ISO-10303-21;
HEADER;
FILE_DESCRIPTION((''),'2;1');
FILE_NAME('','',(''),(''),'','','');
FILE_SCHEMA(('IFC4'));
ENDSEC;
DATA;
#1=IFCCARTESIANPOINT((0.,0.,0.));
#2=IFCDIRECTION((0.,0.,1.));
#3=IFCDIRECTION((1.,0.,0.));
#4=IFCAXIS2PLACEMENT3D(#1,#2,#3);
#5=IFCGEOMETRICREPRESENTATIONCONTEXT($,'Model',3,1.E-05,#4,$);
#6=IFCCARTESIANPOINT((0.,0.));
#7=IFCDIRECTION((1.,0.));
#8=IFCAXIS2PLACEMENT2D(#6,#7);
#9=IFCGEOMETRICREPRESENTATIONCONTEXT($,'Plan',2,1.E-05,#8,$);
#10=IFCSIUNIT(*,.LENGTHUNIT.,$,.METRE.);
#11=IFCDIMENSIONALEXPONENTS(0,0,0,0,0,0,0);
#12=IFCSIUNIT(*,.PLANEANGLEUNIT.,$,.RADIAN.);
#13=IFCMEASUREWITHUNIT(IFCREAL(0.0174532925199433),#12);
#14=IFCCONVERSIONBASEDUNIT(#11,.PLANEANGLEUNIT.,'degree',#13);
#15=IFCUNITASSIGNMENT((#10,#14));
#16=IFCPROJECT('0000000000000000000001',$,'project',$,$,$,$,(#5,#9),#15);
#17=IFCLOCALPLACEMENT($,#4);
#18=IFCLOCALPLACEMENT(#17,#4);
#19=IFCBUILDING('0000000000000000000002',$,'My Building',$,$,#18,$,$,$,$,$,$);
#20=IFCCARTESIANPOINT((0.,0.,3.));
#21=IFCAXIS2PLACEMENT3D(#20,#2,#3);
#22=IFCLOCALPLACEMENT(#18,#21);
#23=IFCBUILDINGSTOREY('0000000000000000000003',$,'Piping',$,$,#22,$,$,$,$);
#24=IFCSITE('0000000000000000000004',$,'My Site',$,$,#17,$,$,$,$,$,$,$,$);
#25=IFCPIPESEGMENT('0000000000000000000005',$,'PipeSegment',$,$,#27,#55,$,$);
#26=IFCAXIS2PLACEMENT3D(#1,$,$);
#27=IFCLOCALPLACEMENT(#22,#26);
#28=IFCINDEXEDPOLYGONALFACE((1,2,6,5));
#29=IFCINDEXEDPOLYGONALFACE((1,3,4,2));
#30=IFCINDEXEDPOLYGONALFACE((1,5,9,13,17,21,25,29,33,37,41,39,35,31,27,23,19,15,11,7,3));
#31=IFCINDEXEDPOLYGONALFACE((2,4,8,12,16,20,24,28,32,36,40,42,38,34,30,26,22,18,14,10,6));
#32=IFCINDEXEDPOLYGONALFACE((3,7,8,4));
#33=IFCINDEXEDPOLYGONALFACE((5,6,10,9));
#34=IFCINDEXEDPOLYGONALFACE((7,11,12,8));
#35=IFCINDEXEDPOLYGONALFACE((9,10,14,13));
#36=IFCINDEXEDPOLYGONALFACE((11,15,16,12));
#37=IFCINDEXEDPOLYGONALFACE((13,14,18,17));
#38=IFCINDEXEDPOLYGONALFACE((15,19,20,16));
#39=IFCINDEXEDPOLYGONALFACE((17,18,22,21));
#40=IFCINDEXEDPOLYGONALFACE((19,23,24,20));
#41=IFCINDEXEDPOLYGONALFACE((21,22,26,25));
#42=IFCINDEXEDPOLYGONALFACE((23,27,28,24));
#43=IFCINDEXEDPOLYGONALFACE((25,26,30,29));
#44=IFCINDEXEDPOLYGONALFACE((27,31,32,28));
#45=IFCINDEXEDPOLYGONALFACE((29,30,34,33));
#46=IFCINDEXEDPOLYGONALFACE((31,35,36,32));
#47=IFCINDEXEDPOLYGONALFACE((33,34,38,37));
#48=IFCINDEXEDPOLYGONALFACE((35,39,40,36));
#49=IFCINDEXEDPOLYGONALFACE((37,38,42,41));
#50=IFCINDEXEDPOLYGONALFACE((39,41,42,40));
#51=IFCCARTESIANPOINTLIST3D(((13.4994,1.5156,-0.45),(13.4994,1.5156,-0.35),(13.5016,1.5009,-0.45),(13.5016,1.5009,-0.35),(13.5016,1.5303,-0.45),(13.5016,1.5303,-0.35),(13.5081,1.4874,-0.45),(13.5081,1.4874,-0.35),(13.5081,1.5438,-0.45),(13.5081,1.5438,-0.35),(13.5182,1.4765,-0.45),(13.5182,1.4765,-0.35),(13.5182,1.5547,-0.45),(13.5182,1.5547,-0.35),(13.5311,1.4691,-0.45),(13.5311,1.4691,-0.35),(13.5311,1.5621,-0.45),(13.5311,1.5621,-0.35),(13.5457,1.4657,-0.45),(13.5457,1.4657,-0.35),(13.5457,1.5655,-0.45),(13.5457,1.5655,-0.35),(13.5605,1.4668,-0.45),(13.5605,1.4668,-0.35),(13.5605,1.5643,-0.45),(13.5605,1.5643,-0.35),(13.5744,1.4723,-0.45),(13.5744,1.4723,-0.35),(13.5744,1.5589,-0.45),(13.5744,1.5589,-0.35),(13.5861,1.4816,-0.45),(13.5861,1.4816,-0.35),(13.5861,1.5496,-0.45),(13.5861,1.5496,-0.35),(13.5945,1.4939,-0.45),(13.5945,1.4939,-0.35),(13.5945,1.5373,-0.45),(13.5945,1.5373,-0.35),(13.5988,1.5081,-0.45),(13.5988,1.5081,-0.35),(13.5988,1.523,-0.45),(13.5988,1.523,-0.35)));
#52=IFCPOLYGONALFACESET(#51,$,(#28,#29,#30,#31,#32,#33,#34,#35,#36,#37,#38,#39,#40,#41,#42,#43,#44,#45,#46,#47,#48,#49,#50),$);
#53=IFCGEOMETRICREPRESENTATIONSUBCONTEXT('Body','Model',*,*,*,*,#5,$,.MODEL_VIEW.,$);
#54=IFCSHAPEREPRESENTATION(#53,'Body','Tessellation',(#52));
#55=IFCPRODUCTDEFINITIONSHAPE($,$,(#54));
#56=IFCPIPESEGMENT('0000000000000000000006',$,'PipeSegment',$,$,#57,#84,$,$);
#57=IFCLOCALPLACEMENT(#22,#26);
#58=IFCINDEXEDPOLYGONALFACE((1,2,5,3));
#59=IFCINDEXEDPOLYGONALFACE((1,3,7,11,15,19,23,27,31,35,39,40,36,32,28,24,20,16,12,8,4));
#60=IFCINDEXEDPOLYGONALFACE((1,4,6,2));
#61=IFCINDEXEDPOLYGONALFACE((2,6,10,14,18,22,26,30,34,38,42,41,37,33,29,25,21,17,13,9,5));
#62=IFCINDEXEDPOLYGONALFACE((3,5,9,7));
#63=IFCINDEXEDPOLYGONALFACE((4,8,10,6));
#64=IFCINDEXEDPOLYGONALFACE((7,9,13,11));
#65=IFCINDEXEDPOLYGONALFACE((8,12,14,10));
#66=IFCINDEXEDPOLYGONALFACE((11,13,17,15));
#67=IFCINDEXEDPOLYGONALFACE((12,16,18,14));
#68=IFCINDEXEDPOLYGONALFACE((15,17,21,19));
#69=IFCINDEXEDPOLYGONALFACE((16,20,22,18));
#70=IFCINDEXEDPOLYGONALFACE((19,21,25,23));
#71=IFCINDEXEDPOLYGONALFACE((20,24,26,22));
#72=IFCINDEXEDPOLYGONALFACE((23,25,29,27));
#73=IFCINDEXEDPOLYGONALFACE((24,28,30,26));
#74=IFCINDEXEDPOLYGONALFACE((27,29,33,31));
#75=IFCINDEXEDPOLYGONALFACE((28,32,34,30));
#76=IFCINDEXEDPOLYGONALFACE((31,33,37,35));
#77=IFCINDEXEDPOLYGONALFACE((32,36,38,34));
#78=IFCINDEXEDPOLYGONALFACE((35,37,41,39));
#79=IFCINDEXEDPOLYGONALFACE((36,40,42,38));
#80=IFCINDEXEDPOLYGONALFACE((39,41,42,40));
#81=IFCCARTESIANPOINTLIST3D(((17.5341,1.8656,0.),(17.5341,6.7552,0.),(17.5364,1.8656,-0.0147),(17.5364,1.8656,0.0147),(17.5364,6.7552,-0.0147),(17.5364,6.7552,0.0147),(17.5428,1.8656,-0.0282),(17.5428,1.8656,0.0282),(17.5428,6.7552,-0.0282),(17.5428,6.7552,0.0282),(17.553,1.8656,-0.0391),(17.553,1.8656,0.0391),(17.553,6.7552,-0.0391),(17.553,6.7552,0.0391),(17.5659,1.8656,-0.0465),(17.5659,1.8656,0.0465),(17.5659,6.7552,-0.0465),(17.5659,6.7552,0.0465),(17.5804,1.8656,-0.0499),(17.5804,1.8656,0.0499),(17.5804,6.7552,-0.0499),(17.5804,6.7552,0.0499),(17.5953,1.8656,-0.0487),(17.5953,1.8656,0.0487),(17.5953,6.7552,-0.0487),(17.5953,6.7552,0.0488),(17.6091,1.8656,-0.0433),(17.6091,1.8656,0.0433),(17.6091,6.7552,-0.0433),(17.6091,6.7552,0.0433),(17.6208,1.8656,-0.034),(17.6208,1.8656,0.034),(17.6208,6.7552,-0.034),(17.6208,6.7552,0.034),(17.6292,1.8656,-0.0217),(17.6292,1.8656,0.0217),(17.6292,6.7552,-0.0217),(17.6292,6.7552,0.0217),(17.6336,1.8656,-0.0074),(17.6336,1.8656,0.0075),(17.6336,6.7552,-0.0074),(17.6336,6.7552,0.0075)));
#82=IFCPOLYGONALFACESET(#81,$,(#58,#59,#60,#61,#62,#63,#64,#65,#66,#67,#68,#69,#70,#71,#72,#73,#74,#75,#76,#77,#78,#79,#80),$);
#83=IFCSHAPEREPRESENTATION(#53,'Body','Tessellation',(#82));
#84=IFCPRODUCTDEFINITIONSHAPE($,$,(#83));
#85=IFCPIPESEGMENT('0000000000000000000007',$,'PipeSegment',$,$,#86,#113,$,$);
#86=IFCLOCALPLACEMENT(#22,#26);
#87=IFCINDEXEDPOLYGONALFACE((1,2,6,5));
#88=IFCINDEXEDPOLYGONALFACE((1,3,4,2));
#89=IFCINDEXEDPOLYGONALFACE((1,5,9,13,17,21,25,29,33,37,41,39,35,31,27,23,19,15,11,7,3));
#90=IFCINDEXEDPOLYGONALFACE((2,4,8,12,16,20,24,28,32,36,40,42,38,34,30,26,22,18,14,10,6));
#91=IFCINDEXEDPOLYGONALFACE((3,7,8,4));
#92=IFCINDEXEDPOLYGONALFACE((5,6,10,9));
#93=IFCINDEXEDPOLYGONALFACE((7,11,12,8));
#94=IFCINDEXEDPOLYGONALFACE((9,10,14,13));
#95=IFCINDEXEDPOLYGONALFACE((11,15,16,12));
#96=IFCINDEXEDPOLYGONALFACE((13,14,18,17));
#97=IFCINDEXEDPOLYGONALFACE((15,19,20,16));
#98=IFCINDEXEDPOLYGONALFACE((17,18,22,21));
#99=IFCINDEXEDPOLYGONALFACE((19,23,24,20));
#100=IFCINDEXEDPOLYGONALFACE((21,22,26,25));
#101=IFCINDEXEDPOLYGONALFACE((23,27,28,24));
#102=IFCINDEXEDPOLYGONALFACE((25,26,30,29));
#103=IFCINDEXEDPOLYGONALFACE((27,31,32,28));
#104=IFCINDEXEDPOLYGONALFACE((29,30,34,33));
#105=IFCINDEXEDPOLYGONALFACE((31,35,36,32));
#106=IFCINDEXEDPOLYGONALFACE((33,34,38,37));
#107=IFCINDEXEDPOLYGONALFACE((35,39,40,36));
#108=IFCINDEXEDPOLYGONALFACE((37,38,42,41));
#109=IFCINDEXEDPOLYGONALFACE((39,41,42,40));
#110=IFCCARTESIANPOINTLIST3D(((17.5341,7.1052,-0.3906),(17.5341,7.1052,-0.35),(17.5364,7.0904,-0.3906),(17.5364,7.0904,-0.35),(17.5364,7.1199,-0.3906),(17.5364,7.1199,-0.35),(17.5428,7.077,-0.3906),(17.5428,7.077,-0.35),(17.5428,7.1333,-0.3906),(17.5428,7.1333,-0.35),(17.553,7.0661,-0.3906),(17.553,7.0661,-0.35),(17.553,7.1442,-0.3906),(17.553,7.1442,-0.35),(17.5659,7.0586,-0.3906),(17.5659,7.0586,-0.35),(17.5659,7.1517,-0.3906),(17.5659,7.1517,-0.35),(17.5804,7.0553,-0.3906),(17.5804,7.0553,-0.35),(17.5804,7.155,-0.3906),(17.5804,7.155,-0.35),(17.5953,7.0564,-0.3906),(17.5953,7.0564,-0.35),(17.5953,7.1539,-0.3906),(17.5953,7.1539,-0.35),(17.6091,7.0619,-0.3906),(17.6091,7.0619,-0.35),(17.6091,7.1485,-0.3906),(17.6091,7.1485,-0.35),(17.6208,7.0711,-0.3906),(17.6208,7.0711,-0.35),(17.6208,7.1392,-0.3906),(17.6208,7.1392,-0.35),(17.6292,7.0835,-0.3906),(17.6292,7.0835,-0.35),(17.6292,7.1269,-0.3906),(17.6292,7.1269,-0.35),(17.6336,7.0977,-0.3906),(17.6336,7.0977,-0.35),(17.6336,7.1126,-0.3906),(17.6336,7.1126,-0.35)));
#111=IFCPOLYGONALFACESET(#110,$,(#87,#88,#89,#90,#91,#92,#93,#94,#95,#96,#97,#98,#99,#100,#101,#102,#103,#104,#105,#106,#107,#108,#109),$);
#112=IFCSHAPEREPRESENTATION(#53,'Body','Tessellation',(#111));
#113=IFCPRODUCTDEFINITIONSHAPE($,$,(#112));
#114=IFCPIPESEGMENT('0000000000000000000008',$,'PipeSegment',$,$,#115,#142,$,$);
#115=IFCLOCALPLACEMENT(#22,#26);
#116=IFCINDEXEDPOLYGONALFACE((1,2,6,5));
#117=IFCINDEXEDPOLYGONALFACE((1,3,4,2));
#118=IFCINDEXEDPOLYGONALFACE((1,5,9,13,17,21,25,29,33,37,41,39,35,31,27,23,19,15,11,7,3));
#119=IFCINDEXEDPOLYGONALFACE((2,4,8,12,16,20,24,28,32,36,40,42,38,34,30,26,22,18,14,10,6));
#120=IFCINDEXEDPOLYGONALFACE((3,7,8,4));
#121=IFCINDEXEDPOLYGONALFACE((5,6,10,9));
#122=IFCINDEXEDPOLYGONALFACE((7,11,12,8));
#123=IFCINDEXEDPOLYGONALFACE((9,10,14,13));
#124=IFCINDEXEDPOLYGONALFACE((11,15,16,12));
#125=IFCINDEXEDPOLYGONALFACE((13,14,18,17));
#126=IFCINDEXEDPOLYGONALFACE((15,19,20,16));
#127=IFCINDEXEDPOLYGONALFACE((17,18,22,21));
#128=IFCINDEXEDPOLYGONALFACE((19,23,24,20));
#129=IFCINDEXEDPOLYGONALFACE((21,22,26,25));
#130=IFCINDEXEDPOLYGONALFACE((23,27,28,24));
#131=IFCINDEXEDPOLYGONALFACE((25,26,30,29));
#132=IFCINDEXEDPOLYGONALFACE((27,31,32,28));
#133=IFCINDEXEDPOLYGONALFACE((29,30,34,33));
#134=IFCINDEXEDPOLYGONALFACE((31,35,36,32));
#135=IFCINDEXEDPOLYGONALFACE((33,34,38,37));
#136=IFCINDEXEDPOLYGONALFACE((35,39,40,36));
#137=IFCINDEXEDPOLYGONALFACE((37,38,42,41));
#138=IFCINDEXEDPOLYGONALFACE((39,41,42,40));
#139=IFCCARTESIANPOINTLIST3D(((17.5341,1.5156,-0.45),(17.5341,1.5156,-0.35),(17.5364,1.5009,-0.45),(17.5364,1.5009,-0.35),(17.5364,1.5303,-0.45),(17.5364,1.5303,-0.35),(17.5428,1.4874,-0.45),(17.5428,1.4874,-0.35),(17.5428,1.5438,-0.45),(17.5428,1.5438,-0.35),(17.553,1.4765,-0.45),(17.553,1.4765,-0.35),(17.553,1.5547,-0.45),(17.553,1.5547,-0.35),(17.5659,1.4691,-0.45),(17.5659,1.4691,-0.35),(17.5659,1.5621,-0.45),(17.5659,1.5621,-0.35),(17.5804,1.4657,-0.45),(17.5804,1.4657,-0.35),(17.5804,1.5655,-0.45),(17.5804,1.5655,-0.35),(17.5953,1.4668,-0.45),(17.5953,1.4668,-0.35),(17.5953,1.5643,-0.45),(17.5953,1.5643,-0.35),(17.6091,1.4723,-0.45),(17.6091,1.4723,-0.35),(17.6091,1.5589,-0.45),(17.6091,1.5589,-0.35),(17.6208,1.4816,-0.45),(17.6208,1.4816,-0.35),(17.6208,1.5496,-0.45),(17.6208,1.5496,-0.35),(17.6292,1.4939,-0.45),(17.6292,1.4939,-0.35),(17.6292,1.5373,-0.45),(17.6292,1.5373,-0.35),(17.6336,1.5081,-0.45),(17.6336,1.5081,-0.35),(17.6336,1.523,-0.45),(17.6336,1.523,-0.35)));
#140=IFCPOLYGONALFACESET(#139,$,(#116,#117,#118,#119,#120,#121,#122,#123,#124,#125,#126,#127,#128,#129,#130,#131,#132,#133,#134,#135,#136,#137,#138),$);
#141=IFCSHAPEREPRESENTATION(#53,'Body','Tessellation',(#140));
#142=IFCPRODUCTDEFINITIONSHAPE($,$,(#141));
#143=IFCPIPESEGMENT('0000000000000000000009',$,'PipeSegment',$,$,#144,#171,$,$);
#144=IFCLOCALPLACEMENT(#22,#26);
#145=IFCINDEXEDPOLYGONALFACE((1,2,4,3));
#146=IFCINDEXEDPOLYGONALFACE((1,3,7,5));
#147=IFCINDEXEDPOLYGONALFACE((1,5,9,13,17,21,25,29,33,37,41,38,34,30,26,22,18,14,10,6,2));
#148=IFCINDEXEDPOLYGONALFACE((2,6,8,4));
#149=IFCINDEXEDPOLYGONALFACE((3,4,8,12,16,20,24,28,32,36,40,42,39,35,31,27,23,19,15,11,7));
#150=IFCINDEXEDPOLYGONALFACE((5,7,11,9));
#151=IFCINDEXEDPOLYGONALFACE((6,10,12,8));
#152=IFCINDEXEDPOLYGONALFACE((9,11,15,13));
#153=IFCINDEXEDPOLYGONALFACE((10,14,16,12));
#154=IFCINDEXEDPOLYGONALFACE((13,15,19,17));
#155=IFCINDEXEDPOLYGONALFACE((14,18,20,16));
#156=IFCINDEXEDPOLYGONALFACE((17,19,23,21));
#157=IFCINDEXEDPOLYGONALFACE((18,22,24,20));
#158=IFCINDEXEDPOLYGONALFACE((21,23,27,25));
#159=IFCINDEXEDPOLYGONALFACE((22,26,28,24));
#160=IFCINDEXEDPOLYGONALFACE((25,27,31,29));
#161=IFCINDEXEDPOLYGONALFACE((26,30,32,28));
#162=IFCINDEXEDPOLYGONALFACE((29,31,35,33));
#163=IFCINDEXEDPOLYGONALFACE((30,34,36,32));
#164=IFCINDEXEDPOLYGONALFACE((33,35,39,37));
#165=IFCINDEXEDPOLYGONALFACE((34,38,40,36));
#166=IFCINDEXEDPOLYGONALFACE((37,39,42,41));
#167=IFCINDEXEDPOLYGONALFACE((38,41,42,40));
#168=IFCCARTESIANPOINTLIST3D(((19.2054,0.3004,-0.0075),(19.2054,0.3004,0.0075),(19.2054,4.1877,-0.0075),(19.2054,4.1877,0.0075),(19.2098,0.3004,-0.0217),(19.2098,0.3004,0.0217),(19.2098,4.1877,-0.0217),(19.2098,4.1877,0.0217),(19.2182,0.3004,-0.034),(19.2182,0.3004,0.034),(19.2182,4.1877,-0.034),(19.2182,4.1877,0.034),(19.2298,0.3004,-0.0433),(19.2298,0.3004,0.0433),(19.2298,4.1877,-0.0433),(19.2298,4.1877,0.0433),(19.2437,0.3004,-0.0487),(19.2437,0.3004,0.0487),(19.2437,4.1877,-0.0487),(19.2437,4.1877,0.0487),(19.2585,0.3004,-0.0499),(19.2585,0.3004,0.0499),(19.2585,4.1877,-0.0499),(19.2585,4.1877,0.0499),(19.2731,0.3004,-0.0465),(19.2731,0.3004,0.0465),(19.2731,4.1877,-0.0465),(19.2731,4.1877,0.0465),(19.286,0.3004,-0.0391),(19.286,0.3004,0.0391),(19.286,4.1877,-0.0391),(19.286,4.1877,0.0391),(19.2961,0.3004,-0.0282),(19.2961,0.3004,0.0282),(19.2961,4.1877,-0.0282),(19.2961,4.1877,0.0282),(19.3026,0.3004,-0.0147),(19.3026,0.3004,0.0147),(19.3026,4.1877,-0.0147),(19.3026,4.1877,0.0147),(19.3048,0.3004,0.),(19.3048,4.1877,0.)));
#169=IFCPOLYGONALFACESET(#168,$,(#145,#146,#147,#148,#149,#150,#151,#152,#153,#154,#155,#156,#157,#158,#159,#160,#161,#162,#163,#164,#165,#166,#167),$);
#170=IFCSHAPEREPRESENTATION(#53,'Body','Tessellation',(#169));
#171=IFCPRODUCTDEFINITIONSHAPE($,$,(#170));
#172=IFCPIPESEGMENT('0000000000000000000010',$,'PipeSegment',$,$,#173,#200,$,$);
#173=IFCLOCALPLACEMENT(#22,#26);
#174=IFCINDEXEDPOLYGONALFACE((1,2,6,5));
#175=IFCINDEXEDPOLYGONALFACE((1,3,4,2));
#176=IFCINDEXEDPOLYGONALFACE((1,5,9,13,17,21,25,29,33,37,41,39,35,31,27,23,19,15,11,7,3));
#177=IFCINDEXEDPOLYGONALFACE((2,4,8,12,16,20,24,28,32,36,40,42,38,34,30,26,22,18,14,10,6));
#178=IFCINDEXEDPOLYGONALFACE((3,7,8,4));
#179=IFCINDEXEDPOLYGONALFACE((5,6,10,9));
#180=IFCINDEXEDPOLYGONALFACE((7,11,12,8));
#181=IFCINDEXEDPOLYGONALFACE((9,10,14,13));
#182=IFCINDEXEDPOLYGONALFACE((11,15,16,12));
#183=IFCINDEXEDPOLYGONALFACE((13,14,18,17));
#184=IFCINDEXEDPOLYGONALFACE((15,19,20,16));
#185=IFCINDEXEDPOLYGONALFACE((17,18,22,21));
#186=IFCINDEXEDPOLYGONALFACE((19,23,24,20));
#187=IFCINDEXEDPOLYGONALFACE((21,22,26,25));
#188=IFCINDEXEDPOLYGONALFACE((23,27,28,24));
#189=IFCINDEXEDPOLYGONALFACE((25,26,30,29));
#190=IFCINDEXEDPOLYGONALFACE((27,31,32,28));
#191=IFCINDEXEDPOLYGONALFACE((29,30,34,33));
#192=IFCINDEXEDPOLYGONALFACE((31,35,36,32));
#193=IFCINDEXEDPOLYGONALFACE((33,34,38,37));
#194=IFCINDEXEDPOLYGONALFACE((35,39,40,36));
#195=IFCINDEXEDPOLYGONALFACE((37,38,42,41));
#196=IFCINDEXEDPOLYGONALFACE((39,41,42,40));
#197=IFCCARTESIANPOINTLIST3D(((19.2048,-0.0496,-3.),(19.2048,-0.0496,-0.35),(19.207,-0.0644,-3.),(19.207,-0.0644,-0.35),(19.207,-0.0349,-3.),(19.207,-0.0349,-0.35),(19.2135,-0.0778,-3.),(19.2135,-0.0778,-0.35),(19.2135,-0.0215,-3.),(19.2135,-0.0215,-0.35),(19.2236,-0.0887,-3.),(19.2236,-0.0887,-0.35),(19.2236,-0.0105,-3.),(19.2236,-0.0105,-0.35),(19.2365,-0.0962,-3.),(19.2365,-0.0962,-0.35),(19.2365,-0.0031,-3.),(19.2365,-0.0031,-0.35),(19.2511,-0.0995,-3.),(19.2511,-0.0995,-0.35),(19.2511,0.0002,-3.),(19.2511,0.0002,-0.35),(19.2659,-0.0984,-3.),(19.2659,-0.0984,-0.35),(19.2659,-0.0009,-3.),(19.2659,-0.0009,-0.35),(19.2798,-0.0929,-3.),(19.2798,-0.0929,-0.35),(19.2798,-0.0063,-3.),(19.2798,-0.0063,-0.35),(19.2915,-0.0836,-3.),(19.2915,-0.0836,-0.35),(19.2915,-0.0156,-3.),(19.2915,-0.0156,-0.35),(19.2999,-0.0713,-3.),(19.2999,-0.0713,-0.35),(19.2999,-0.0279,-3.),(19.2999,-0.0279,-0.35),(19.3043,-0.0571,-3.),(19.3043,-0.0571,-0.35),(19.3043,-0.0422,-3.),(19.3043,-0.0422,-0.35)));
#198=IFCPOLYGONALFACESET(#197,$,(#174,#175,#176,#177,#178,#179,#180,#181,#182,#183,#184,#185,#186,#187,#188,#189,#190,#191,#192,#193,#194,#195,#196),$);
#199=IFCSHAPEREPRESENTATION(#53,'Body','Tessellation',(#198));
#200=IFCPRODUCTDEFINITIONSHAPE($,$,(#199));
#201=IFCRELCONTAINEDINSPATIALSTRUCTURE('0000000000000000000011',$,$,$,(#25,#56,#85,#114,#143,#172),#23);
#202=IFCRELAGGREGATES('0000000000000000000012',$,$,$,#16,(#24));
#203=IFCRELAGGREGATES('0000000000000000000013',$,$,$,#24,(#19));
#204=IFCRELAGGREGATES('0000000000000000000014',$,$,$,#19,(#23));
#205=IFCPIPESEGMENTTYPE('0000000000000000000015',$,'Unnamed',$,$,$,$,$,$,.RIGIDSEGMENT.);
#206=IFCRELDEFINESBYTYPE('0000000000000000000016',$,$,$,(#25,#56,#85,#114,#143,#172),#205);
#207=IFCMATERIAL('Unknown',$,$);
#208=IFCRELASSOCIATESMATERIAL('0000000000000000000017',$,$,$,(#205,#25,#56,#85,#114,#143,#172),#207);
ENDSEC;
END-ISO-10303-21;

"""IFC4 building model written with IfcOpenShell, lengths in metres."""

from ifc_helpers import new_model, entity, si_unit, converted_unit, frame, origin_with_axes, origin_2d_with_axis, place, context, subcontext, project, spatial, circle, extrude, material, material_profile, profile_set, profile_usage, type_object, element, save


model = new_model("IFC4")

# Units and contexts
model_context = context("Model", 3, precision=1e-05, world=origin_with_axes())
plan_context = context("Plan", 2, precision=1e-05, world=origin_2d_with_axis())
body_context = subcontext(model_context, "Body", "Model", "MODEL_VIEW")
ifc_project = project(units=[si_unit("LENGTHUNIT", "METRE"), converted_unit("PLANEANGLEUNIT", "degree", entity("IfcReal", 0.0174532925199433), si_unit("PLANEANGLEUNIT", "RADIAN"), dimensions=[0, 0, 0, 0, 0, 0, 0])], contexts=[model_context, plan_context])

# Site, building, storey
site_placement = place(None, origin_with_axes())
site = spatial("IfcSite", under=ifc_project, at=site_placement, Name="My Site")
building_placement = place(site_placement, origin_with_axes())
building = spatial("IfcBuilding", under=site, at=building_placement, Name="My Building")
storey_placement = place(building_placement, frame((0.0, 0.0, 3.0), z_axis=(0.0, 0.0, 1.0), x_axis=(1.0, 0.0, 0.0)))
storey = spatial("IfcBuildingStorey", under=building, at=storey_placement, Name="Piping")

# Pipe segments
ifc_material = material(Name="Unknown")
ifc_material_profile = material_profile(ifc_material, circle(Radius=0.05))
ifc_profile_set = profile_set([ifc_material_profile])
pipe_segment_type = type_object("IfcPipeSegmentType", Name="Unnamed", PredefinedType="RIGIDSEGMENT", material=ifc_profile_set)
ifc_profile_usage_1 = profile_usage(ifc_profile_set, cardinal=5)
pipe_segment_1_placement = place(storey_placement, frame((13.5494, 1.5156, -0.35), z_axis=(0.0, 0.0, -1.0), x_axis=(-1.0, 0.0, 0.0)))
element("IfcPipeSegment", 1, at=pipe_segment_1_placement, inside=storey, type_object=pipe_segment_type, material=ifc_profile_usage_1, Name="PipeSegment", context=body_context, shape_type="SweptSolid", body=[
    extrude(circle(Radius=0.05), origin_with_axes(), (0.0, 0.0, 1.0), 0.1),
])
ifc_profile_usage_2 = profile_usage(ifc_profile_set, cardinal=5)
pipe_segment_2_placement = place(storey_placement, frame((17.5841, 1.8656, 0.0), z_axis=(0.0, 1.0, 0.0), x_axis=(-1.0, 0.0, 0.0)))
element("IfcPipeSegment", 2, at=pipe_segment_2_placement, inside=storey, type_object=pipe_segment_type, material=ifc_profile_usage_2, Name="PipeSegment", context=body_context, shape_type="SweptSolid", body=[
    extrude(circle(Radius=0.05), origin_with_axes(), (0.0, 0.0, 1.0), 4.8896),
])
ifc_profile_usage_3 = profile_usage(ifc_profile_set, cardinal=5)
pipe_segment_3_placement = place(storey_placement, frame((17.5841, 7.1052, -0.35), z_axis=(0.0, 0.0, -1.0), x_axis=(-1.0, 0.0, 0.0)))
element("IfcPipeSegment", 3, at=pipe_segment_3_placement, inside=storey, type_object=pipe_segment_type, material=ifc_profile_usage_3, Name="PipeSegment", context=body_context, shape_type="SweptSolid", body=[
    extrude(circle(Radius=0.05), origin_with_axes(), (0.0, 0.0, 1.0), 0.0406),
])
ifc_profile_usage_4 = profile_usage(ifc_profile_set, cardinal=5)
pipe_segment_4_placement = place(storey_placement, frame((17.5841, 1.5156, -0.35), z_axis=(0.0, 0.0, -1.0), x_axis=(-1.0, 0.0, 0.0)))
element("IfcPipeSegment", 4, at=pipe_segment_4_placement, inside=storey, type_object=pipe_segment_type, material=ifc_profile_usage_4, Name="PipeSegment", context=body_context, shape_type="SweptSolid", body=[
    extrude(circle(Radius=0.05), origin_with_axes(), (0.0, 0.0, 1.0), 0.1),
])
ifc_profile_usage_5 = profile_usage(ifc_profile_set, cardinal=5)
pipe_segment_5_placement = place(storey_placement, frame((19.2548, 4.1877, 0.0), z_axis=(0.0, -1.0, 0.0), x_axis=(1.0, 0.0, 0.0)))
element("IfcPipeSegment", 5, at=pipe_segment_5_placement, inside=storey, type_object=pipe_segment_type, material=ifc_profile_usage_5, Name="PipeSegment", context=body_context, shape_type="SweptSolid", body=[
    extrude(circle(Radius=0.05), origin_with_axes(), (0.0, 0.0, 1.0), 3.8874),
])
ifc_profile_usage_6 = profile_usage(ifc_profile_set, cardinal=5)
pipe_segment_6_placement = place(storey_placement, frame((19.2548, -0.0496, -0.35), z_axis=(0.0, 0.0, -1.0), x_axis=(-1.0, 0.0, 0.0)))
element("IfcPipeSegment", 6, at=pipe_segment_6_placement, inside=storey, type_object=pipe_segment_type, material=ifc_profile_usage_6, Name="PipeSegment", context=body_context, shape_type="SweptSolid", body=[
    extrude(circle(Radius=0.05), origin_with_axes(), (0.0, 0.0, 1.0), 2.65),
])

save(model, "model.ifc")
